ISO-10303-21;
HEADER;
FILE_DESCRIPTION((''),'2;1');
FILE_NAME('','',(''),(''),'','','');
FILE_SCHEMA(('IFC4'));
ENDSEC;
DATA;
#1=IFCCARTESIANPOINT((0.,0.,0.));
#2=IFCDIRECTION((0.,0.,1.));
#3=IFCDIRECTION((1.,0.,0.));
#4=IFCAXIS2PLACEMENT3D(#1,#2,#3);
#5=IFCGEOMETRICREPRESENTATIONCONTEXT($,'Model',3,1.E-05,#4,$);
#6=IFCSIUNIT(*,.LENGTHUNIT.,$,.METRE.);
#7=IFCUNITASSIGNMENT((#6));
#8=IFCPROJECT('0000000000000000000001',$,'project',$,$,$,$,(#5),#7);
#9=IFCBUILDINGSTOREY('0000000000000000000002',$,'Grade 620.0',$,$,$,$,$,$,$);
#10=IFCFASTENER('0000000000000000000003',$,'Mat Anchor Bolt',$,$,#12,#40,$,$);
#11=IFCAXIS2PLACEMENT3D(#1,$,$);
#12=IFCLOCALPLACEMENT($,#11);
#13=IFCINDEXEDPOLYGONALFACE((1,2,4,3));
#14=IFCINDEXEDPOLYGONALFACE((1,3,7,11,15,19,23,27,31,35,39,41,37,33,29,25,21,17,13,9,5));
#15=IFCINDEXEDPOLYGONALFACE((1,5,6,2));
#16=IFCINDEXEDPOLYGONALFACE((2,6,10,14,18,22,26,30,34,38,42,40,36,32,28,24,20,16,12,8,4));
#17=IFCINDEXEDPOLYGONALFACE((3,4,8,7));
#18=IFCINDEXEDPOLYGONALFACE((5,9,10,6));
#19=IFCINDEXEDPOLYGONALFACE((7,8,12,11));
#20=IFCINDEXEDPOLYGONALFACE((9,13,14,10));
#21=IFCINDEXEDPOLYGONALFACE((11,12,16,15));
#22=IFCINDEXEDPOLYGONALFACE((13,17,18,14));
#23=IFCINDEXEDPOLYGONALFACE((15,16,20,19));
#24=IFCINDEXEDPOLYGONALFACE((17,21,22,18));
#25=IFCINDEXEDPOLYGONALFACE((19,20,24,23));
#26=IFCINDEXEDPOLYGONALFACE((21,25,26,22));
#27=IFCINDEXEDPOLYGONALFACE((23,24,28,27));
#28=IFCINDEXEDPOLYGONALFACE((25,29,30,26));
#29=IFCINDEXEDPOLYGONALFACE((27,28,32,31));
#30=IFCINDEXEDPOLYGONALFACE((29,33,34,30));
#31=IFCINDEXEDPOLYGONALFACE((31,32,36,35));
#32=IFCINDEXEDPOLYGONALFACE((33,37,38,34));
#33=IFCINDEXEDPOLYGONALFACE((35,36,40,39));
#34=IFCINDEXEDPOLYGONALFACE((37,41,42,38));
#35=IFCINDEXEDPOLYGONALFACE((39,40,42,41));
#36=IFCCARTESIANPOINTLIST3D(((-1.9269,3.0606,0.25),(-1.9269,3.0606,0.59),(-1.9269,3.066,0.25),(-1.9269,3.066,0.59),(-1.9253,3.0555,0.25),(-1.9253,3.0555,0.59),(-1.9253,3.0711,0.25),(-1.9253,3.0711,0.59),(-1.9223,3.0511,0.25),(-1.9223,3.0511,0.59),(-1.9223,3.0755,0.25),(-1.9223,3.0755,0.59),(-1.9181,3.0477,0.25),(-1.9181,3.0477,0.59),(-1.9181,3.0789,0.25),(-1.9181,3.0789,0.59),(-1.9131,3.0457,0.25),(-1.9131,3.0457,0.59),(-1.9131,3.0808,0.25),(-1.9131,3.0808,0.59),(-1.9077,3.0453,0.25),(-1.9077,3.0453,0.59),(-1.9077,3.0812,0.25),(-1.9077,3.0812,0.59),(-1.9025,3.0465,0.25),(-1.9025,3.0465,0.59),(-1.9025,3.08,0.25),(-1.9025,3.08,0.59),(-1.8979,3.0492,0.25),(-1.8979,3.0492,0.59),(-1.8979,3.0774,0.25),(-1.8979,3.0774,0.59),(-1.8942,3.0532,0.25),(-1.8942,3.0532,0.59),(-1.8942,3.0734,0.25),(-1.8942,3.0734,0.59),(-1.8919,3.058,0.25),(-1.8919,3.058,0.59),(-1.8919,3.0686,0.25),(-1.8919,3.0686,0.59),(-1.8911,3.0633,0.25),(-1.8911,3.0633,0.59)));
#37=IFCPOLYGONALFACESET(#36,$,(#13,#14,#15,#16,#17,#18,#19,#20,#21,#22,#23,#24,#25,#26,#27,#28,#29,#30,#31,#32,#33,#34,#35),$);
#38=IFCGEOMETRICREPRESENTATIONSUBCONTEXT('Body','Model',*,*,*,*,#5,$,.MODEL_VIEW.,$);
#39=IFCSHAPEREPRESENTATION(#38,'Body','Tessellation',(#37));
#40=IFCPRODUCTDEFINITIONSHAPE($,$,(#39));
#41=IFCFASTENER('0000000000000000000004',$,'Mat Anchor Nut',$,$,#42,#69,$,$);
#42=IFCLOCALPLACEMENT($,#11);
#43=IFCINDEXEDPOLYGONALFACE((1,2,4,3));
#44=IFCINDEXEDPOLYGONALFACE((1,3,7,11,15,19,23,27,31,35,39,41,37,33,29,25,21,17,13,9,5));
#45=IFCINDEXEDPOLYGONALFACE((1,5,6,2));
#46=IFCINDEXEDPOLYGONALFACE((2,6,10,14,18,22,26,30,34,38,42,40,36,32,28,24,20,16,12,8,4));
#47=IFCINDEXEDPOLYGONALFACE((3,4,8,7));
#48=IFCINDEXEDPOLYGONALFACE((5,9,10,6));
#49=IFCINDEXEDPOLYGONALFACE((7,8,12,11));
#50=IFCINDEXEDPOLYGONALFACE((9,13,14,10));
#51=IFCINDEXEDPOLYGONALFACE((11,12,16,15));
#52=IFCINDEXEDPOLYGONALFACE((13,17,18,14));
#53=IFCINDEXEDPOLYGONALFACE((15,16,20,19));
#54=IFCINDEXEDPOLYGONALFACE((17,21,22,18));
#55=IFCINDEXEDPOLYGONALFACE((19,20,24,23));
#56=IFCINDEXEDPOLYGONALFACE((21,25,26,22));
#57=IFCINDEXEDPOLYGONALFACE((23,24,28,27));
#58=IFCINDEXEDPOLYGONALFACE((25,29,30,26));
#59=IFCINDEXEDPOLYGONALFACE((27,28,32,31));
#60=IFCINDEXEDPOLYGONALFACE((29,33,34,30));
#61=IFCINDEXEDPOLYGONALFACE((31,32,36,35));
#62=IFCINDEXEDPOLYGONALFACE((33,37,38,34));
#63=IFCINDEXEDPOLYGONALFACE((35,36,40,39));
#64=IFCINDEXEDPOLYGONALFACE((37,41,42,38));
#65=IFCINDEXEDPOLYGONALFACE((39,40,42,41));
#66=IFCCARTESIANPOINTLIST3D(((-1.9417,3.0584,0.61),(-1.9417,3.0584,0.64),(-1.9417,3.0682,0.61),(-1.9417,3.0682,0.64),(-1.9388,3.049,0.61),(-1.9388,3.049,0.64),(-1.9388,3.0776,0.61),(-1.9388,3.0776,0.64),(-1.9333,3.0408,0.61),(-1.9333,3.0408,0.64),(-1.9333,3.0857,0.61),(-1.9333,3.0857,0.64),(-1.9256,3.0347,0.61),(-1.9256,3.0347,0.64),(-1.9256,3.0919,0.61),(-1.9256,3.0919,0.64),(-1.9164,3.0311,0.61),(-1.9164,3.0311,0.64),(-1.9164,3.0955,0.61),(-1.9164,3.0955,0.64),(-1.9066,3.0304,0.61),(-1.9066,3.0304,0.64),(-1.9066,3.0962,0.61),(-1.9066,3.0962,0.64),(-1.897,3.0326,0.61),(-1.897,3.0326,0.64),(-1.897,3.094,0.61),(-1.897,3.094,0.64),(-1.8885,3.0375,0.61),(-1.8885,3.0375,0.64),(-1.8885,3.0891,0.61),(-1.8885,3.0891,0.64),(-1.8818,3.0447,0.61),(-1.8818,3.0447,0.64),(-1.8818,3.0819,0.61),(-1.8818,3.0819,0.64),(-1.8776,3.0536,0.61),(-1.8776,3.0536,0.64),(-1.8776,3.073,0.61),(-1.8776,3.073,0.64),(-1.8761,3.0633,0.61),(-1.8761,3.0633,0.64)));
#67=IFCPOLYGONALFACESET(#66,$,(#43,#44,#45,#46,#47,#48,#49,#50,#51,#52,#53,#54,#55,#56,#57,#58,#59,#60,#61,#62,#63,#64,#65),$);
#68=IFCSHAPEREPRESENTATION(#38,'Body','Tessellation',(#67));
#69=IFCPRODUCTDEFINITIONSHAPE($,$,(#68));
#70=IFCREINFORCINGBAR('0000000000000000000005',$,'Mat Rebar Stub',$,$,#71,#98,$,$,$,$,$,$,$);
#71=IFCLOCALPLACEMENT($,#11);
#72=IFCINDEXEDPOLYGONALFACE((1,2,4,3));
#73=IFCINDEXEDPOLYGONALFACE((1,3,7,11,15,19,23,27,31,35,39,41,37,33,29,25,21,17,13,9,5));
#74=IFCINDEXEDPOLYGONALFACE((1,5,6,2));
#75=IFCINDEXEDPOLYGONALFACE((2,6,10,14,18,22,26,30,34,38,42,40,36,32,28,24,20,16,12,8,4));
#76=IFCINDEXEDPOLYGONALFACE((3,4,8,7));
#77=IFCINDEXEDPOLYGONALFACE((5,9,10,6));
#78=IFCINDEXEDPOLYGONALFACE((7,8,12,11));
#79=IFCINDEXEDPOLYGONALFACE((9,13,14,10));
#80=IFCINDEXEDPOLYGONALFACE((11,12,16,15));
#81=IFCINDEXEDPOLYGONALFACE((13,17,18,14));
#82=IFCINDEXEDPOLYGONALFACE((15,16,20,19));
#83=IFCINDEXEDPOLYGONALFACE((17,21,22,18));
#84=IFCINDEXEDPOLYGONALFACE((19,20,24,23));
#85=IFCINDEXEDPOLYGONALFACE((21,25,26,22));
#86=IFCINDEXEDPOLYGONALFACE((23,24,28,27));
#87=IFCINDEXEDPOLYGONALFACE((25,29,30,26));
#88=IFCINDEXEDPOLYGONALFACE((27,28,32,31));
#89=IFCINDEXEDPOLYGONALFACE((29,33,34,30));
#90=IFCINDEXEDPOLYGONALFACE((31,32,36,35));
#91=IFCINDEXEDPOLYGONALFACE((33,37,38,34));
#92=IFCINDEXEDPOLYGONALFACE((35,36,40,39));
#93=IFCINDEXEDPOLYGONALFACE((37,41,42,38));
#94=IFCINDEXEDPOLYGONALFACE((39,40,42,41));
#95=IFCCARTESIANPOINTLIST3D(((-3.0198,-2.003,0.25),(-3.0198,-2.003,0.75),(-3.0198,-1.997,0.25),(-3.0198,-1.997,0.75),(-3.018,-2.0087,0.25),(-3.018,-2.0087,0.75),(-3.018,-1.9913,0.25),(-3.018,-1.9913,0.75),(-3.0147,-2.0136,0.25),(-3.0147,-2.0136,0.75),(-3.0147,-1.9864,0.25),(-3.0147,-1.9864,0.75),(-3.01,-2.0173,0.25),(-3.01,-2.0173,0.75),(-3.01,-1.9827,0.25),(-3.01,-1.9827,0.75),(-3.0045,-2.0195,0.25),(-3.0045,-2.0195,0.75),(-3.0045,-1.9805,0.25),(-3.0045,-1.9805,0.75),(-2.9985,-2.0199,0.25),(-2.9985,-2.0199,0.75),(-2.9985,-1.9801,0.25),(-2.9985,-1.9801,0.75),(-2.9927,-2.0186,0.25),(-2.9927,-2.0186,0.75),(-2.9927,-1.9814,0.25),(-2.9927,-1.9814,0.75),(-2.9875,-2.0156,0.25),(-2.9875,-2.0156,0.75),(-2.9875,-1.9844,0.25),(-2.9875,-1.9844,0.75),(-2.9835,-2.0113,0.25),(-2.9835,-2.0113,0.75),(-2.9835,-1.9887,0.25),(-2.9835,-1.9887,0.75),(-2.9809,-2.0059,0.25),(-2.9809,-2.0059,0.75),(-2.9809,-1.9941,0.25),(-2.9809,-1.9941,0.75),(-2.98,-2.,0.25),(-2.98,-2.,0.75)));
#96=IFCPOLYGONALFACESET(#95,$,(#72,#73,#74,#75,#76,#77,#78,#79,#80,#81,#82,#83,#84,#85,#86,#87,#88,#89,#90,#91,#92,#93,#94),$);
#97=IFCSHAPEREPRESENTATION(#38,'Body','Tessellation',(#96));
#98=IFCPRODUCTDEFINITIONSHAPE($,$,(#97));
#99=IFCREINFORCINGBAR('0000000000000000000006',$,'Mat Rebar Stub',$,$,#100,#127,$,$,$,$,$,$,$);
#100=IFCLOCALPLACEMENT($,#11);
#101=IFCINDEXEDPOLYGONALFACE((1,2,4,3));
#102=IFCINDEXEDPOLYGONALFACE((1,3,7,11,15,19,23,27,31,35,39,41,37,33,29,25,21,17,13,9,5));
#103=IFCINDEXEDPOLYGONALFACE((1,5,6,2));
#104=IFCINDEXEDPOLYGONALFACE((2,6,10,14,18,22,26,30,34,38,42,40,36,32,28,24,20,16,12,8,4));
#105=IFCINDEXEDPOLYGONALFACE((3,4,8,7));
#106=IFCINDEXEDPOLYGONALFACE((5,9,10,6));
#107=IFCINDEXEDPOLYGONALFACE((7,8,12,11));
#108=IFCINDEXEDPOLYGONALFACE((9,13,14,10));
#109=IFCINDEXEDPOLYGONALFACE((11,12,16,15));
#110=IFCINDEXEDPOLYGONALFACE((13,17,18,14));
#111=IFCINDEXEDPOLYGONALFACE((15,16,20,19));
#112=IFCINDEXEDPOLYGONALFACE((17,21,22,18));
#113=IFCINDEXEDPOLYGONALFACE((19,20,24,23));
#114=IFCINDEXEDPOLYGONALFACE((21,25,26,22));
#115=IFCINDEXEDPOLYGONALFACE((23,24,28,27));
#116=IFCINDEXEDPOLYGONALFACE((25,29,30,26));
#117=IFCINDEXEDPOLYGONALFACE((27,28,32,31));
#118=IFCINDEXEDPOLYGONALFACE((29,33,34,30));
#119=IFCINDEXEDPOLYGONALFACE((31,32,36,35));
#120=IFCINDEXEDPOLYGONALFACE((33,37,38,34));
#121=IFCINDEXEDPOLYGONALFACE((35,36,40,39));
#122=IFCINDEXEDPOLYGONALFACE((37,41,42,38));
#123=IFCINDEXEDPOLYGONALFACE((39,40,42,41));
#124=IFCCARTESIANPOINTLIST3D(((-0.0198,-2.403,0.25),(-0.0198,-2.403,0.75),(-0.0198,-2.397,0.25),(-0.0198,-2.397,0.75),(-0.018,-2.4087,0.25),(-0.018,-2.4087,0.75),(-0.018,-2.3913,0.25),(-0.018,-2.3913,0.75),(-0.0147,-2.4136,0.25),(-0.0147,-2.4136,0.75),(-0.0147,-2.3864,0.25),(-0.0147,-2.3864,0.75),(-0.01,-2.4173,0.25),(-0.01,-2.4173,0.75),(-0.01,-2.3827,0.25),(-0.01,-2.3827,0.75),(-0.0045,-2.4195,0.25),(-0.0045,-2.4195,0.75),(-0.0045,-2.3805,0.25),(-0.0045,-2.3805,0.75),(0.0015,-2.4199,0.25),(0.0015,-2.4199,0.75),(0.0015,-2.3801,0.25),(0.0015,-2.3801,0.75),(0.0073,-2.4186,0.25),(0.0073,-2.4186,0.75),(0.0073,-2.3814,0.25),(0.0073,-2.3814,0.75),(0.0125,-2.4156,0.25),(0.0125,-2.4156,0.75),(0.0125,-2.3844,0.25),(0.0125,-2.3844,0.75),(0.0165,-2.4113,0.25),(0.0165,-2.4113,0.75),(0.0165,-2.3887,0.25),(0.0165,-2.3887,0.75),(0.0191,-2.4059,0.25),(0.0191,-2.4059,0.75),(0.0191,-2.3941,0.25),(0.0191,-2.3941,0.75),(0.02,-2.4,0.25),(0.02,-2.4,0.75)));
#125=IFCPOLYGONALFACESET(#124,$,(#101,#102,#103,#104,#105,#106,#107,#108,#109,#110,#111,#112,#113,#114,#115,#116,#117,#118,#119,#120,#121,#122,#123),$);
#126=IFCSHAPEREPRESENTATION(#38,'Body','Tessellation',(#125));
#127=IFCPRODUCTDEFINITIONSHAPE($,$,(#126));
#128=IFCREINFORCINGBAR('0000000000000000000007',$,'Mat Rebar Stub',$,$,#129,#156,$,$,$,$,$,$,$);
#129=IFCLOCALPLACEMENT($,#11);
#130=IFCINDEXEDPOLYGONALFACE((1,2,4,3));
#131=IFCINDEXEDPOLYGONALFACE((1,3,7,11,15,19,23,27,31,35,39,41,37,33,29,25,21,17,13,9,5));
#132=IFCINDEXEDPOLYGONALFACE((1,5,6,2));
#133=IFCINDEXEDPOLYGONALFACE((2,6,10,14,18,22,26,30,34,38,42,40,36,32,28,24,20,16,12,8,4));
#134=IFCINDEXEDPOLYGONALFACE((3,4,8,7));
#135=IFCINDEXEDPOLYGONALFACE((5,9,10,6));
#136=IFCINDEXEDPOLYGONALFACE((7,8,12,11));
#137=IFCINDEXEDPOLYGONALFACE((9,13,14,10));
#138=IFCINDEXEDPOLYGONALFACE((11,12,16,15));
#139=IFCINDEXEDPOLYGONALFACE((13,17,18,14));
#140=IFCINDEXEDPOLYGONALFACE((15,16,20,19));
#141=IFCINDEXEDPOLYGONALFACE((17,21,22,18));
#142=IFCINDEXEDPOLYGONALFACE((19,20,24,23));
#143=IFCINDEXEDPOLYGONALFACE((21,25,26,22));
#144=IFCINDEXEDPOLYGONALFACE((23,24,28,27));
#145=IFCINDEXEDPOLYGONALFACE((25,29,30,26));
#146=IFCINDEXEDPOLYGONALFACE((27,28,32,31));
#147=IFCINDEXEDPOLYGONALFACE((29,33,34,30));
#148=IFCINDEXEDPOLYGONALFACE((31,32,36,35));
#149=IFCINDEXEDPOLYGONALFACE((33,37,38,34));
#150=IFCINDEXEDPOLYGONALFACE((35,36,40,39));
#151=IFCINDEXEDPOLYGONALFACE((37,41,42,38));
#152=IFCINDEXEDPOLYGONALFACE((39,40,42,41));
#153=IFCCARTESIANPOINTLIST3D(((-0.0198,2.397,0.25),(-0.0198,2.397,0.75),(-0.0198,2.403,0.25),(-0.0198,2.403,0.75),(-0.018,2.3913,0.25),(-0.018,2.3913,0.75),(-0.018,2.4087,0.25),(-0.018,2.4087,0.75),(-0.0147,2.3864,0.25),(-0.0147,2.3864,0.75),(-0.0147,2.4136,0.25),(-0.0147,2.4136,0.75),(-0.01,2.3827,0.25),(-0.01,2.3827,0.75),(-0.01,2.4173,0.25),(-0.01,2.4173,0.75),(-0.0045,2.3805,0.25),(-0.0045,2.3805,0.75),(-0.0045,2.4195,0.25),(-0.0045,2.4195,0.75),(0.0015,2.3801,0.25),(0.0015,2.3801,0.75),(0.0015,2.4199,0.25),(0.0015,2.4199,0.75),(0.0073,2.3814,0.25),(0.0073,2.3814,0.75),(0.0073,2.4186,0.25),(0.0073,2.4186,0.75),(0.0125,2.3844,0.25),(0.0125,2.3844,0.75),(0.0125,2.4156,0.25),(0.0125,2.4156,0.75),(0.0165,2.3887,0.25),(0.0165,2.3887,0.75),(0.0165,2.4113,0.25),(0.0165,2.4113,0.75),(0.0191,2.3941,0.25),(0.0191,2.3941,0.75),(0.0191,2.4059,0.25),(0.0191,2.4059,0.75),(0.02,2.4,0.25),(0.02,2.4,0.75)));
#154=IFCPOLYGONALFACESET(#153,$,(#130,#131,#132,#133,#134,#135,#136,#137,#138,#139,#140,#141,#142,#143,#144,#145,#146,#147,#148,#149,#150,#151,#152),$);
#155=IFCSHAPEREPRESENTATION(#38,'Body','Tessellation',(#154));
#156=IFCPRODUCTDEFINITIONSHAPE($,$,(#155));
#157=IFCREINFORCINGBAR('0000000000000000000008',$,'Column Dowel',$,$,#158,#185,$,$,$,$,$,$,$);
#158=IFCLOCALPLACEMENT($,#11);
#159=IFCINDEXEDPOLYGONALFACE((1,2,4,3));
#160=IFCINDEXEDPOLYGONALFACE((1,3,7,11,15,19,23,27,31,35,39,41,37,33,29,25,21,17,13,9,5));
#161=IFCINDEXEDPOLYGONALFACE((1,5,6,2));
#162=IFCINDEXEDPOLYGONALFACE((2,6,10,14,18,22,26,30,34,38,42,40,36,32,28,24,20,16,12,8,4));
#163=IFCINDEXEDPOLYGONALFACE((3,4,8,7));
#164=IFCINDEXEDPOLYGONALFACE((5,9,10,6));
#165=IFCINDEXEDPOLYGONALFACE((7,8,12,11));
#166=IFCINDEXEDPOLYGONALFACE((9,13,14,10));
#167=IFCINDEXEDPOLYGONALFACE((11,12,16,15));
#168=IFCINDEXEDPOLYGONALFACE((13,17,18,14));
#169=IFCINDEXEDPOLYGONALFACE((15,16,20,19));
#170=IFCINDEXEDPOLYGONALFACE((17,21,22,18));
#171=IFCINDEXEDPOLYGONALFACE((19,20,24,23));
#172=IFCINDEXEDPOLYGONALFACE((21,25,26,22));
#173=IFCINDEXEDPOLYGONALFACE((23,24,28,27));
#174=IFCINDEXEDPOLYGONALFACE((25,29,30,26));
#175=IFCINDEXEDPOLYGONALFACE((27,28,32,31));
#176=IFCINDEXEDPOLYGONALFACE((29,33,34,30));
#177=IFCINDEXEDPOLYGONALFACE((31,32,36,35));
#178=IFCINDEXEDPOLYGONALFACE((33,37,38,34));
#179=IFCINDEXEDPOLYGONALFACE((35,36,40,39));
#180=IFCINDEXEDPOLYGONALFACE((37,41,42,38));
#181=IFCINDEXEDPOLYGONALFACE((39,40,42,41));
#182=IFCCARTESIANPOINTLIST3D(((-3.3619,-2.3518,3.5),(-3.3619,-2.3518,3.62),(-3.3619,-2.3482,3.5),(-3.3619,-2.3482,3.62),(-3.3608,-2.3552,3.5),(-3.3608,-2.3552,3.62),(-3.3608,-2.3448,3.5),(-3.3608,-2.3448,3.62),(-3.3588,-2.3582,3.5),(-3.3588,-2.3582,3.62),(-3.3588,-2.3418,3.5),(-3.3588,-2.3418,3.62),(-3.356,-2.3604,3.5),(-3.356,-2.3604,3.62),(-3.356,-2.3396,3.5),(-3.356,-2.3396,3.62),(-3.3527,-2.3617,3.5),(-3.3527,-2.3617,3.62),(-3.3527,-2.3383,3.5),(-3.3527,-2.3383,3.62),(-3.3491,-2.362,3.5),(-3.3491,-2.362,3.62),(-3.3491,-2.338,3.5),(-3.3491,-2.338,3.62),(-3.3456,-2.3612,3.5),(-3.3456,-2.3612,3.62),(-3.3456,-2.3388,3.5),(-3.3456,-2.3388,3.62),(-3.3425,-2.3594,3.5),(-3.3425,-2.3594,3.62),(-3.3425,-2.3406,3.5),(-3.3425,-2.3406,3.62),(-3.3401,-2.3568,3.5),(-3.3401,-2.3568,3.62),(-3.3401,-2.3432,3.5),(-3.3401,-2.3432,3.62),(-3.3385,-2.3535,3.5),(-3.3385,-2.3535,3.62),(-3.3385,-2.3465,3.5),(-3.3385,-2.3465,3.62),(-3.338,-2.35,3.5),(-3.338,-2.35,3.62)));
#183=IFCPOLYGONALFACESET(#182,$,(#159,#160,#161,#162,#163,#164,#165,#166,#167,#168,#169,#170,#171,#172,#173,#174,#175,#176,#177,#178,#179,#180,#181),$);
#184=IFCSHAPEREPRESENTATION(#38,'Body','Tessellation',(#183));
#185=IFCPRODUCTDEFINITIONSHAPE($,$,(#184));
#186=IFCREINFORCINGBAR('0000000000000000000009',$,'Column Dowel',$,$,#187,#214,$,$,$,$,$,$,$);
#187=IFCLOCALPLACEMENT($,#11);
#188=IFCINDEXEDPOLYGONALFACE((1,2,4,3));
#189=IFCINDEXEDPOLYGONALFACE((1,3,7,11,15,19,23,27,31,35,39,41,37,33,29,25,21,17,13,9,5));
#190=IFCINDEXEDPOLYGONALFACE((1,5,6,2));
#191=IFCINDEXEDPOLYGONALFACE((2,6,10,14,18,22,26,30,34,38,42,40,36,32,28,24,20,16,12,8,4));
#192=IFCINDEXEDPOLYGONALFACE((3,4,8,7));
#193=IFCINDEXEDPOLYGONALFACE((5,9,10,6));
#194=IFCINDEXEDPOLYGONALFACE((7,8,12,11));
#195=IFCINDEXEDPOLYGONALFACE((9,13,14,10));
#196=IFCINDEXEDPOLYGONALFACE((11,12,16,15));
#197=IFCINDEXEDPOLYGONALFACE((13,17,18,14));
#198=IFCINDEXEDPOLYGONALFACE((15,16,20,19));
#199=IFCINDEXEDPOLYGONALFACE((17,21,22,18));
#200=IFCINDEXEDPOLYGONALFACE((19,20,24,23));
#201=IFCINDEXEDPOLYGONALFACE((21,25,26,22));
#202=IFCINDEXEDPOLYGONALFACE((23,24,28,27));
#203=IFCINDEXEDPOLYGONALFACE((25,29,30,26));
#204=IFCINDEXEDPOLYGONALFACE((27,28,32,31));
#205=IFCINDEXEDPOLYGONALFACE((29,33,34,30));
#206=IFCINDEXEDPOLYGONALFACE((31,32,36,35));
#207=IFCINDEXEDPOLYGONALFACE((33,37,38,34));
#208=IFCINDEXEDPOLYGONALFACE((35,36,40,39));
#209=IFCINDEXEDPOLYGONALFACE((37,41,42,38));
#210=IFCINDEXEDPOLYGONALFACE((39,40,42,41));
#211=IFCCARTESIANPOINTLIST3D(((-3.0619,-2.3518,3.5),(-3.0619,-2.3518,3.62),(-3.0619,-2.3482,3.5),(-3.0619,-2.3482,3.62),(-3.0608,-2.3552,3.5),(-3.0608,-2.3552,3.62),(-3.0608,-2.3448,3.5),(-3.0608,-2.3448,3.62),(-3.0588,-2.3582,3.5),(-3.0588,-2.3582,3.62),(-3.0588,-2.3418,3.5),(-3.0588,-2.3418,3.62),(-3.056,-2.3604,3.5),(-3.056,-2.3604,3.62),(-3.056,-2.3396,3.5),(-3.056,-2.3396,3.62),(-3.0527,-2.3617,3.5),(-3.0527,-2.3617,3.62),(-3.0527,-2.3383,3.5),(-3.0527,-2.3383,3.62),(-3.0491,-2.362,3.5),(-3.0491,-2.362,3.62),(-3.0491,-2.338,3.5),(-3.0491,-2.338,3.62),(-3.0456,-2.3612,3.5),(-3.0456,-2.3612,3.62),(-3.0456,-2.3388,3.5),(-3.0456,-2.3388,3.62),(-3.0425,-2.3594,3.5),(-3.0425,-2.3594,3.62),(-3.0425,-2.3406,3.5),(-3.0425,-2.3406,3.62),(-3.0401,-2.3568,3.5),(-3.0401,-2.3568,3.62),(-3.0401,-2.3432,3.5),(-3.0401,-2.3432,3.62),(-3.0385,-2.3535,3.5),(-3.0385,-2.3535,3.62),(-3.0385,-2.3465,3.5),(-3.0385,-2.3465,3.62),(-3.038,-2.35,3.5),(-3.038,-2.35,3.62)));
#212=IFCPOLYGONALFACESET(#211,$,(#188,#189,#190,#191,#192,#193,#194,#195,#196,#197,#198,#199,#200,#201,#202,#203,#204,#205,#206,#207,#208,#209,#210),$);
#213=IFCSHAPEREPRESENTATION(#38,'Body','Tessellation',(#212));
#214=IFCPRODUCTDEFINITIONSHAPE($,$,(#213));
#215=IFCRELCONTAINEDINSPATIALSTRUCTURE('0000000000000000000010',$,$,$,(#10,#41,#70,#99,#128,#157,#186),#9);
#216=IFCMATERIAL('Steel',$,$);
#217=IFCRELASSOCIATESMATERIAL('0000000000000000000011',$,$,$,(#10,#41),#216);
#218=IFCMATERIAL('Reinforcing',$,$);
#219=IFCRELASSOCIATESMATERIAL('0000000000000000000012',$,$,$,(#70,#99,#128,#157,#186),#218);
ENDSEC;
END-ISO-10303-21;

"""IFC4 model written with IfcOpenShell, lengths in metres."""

from ifc_helpers import new_model, si_unit, frame, origin_with_axes, place, context, subcontext, project, spatial, circle, extrude, material, element, save


model = new_model("IFC4")

# Units and contexts
model_context = context("Model", 3, precision=1e-05, world=origin_with_axes())
body_context = subcontext(model_context, "Body", "Model", "MODEL_VIEW")
ifc_project = project(units=[si_unit("LENGTHUNIT", "METRE")], contexts=[model_context])

# Storey
storey = spatial("IfcBuildingStorey", Name="Grade 620.0")

# Fasteners
ifc_material_1 = material(Name="Steel")
fastener_1_placement = place(None, frame((-1.9091, 3.0633, 0.25), z_axis=(0.0, 0.0, 1.0), x_axis=(1.0, 0.0, 0.0)))
element("IfcFastener", 1, at=fastener_1_placement, inside=storey, material=ifc_material_1, Name="Mat Anchor Bolt", context=body_context, shape_type="SweptSolid", body=[
    extrude(circle(Radius=0.018), origin_with_axes(), (0.0, 0.0, 1.0), 0.34),
])
fastener_2_placement = place(None, frame((-1.9091, 3.0633, 0.61), z_axis=(0.0, 0.0, 1.0), x_axis=(1.0, 0.0, 0.0)))
element("IfcFastener", 2, at=fastener_2_placement, inside=storey, material=ifc_material_1, Name="Mat Anchor Nut", context=body_context, shape_type="SweptSolid", body=[
    extrude(circle(Radius=0.033), origin_with_axes(), (0.0, 0.0, 1.0), 0.03),
])

# Reinforcing bars
ifc_material_2 = material(Name="Reinforcing")
for number, where, z_axis, x_axis, name in (
    (3, (-3.0, -2.0, 0.25), (0.0, 0.0, 1.0), (1.0, 0.0, 0.0), "Mat Rebar Stub"),
    (4, (0.0, -2.4, 0.25), (0.0, 0.0, 1.0), (1.0, 0.0, 0.0), "Mat Rebar Stub"),
    (5, (0.0, 2.4, 0.25), (0.0, 0.0, 1.0), (1.0, 0.0, 0.0), "Mat Rebar Stub"),
):
    element("IfcReinforcingBar", number, at=place(None, frame(where, z_axis=z_axis, x_axis=x_axis)), inside=storey, material=ifc_material_2, Name=name, context=body_context, shape_type="SweptSolid", body=[
        extrude(circle(Radius=0.02), origin_with_axes(), (0.0, 0.0, 1.0), 0.5),
    ])
for number, where, z_axis, x_axis, name in (
    (6, (-3.35, -2.35, 3.5), (0.0, 0.0, 1.0), (1.0, 0.0, 0.0), "Column Dowel"),
    (7, (-3.05, -2.35, 3.5), (0.0, 0.0, 1.0), (1.0, 0.0, 0.0), "Column Dowel"),
):
    element("IfcReinforcingBar", number, at=place(None, frame(where, z_axis=z_axis, x_axis=x_axis)), inside=storey, material=ifc_material_2, Name=name, context=body_context, shape_type="SweptSolid", body=[
        extrude(circle(Radius=0.012), origin_with_axes(), (0.0, 0.0, 1.0), 0.12),
    ])

save(model, "model.ifc")
